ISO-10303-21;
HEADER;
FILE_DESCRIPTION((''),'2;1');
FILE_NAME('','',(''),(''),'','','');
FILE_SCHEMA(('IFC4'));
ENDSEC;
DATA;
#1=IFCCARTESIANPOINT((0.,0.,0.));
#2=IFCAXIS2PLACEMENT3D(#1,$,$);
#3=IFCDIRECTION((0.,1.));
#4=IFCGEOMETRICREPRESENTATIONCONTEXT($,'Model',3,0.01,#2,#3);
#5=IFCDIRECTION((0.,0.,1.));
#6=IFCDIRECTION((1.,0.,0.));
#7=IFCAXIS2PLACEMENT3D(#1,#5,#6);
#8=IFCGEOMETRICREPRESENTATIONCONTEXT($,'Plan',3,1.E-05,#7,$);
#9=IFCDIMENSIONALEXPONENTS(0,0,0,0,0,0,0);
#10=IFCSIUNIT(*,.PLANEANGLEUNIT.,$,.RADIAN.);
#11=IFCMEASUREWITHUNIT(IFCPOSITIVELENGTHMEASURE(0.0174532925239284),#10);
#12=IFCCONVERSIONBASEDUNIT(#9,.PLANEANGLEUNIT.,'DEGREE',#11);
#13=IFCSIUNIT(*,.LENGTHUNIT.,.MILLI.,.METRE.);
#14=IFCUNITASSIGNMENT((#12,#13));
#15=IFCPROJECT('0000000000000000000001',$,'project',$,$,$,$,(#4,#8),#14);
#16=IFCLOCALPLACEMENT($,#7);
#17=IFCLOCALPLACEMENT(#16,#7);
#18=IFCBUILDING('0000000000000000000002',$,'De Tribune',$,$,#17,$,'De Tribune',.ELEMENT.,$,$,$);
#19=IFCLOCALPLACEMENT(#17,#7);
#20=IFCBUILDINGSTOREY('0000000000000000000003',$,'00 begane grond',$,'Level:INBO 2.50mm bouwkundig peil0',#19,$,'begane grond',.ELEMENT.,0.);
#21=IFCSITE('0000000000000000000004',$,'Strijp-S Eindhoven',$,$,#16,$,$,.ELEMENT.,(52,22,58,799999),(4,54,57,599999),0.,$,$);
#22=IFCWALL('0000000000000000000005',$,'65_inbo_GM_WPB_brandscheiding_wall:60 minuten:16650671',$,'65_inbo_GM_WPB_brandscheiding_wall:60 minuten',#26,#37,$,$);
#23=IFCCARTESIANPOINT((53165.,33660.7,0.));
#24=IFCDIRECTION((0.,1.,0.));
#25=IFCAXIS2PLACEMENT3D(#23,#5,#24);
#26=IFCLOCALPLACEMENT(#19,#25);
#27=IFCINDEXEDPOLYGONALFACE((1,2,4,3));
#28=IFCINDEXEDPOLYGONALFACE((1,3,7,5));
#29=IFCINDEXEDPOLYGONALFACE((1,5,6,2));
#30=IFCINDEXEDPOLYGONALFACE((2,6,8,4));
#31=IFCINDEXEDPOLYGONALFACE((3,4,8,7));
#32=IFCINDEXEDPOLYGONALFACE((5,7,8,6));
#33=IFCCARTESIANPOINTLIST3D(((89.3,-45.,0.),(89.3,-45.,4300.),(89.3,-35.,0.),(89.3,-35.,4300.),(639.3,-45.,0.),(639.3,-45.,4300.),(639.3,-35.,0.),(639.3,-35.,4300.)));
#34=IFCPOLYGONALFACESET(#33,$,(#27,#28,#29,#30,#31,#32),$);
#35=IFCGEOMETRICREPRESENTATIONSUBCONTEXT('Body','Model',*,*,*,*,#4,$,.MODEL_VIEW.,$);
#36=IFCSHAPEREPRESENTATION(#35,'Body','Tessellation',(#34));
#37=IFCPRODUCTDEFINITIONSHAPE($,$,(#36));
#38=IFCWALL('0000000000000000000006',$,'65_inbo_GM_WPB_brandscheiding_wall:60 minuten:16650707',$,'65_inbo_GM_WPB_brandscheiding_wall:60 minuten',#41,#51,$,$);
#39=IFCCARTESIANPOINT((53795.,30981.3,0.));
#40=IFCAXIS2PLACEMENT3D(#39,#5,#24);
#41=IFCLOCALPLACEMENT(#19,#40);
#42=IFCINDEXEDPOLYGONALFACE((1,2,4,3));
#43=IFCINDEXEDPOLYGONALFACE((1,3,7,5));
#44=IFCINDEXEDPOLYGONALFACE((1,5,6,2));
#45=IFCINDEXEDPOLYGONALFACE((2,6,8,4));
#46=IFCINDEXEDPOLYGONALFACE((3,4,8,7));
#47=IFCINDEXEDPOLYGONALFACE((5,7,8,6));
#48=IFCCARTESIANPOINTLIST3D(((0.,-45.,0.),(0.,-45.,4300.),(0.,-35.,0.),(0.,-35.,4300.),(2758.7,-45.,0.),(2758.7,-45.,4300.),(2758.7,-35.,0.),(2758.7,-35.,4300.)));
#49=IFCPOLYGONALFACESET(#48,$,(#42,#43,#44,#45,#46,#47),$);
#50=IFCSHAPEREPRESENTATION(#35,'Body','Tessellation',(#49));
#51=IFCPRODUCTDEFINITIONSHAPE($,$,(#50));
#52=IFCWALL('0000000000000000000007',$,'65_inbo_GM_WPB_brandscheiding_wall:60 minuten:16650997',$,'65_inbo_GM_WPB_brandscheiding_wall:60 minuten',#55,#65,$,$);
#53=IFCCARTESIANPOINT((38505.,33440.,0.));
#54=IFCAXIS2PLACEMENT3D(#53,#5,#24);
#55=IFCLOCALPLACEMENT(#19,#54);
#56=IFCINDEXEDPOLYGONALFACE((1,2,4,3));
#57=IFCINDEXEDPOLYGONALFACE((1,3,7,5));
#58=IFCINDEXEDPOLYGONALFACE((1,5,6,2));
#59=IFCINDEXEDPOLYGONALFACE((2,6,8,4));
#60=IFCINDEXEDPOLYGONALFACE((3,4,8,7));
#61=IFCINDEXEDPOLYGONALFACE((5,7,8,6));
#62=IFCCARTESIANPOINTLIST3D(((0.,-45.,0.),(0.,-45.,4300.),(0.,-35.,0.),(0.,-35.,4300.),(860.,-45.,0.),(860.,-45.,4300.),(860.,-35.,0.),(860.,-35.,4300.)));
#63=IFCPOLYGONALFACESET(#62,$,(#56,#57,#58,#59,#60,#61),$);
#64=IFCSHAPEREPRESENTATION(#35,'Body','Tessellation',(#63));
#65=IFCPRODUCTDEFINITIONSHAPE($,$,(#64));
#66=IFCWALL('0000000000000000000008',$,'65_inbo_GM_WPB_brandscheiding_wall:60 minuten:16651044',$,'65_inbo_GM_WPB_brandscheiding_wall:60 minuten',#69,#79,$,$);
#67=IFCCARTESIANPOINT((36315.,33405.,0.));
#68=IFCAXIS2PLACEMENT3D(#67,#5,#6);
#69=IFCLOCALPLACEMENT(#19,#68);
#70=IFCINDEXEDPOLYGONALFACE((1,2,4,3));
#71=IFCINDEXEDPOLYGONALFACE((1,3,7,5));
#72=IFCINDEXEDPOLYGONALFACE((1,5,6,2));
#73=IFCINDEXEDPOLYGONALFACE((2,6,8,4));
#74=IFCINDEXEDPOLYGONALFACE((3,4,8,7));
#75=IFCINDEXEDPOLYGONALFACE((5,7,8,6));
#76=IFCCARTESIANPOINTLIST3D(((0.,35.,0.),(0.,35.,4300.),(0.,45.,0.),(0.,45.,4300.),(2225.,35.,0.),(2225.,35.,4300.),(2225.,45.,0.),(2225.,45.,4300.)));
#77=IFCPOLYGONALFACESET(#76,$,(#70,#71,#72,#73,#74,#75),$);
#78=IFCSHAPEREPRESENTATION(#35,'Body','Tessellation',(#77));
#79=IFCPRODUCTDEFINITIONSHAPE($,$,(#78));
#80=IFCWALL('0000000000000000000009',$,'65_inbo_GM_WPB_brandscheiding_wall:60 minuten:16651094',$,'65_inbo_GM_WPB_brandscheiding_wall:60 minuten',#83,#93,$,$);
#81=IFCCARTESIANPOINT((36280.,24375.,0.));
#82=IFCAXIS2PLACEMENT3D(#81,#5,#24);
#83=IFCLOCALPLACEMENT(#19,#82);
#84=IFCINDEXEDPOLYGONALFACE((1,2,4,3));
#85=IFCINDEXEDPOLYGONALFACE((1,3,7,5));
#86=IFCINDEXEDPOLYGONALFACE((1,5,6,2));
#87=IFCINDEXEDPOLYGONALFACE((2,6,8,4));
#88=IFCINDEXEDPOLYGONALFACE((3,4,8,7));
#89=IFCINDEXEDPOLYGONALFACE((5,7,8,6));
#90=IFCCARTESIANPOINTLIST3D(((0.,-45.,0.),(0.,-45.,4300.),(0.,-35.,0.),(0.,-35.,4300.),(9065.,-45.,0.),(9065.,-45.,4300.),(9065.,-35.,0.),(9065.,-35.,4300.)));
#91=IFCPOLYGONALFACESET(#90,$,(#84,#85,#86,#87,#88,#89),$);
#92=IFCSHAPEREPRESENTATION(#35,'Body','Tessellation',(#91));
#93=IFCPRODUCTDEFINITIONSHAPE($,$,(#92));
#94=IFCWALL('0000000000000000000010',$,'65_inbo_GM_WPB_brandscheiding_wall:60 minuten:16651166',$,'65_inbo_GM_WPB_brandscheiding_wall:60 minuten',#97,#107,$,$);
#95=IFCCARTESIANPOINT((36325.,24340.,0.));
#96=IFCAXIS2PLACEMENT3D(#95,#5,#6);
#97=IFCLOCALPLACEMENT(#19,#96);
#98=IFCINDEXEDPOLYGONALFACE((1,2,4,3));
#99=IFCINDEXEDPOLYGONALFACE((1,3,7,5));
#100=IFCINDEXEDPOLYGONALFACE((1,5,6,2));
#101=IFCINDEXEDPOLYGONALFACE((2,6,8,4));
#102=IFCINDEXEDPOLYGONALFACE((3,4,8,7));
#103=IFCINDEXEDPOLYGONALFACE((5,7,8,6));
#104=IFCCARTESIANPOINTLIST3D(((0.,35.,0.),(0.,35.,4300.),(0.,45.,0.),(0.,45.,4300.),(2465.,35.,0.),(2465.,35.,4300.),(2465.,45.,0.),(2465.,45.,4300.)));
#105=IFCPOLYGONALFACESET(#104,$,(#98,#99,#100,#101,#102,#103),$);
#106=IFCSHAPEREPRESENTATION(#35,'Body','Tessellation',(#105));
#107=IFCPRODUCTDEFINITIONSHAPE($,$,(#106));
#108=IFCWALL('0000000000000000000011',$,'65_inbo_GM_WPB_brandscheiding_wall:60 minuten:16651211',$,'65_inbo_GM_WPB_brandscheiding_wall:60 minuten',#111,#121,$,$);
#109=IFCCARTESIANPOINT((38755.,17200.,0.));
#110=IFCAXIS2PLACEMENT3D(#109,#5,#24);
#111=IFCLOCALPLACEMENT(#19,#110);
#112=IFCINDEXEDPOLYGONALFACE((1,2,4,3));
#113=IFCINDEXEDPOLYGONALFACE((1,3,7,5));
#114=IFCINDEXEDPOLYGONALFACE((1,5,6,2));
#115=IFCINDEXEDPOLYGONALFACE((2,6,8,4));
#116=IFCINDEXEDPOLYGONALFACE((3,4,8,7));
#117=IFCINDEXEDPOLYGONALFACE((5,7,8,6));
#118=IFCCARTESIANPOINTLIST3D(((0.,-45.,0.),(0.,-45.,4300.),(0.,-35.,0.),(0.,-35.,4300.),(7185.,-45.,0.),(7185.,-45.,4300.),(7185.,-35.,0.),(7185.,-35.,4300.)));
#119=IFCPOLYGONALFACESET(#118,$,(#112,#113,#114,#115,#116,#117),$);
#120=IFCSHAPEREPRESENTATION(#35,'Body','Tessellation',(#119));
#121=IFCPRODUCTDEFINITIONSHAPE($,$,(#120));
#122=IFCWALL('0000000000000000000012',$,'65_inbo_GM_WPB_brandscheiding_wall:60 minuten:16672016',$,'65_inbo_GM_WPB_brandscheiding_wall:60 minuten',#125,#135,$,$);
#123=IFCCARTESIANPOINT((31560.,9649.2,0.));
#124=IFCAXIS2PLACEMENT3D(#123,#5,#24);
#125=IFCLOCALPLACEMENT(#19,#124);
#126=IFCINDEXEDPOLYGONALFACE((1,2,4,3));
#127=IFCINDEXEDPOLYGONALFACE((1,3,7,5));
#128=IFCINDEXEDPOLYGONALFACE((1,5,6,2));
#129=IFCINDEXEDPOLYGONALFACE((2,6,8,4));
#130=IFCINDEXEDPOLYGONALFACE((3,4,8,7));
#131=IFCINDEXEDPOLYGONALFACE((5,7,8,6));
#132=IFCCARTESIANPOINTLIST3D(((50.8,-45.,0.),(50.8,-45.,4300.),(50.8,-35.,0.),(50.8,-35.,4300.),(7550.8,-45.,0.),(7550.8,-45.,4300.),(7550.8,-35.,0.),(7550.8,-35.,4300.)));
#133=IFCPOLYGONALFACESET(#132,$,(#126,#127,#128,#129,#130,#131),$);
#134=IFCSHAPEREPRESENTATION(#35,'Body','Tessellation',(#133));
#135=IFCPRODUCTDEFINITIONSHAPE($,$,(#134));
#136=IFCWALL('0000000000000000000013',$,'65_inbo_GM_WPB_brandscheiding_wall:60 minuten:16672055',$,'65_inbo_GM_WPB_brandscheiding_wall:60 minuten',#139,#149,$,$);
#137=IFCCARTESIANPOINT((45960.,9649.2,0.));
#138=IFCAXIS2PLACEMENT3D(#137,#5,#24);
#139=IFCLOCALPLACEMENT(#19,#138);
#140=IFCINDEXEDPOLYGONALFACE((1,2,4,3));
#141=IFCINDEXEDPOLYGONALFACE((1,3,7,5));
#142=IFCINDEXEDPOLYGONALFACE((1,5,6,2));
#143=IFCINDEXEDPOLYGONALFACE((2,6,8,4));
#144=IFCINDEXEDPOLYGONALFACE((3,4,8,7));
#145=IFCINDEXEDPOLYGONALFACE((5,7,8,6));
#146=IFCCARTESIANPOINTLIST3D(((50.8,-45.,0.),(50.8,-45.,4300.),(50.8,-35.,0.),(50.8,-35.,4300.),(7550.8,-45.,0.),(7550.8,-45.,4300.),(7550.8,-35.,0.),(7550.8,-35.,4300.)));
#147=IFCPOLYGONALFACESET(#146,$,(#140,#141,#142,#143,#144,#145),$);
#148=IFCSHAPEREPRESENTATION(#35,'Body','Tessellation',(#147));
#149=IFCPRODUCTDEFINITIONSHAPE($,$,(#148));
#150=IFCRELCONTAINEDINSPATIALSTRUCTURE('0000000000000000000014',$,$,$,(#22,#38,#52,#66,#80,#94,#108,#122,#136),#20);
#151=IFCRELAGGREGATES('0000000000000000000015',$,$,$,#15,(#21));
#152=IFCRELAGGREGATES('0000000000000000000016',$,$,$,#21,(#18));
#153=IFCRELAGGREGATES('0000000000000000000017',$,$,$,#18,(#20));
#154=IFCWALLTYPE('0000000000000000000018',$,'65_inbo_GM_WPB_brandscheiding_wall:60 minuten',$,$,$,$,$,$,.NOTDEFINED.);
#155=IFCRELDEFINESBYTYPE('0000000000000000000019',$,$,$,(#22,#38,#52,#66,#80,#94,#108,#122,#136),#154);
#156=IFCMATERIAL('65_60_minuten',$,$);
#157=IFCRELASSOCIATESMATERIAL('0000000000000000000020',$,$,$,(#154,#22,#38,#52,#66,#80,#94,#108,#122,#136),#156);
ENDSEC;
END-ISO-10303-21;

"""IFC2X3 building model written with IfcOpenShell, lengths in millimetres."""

from ifc_helpers import new_model, entity, si_unit, converted_unit, direction, frame, frame_2d, origin, origin_with_axes, place, context, subcontext, project, spatial, rectangle, extrude, material, type_object, element, save


model = new_model("IFC2X3")

# Units and contexts
model_context = context("Model", 3, precision=0.01, world=origin(), true_north=direction((0.0, 1.0)))
plan_context = context("Plan", 3, precision=1e-05, world=origin_with_axes())
body_context = subcontext(model_context, "Body", "Model", "MODEL_VIEW")
ifc_project = project(units=[converted_unit("PLANEANGLEUNIT", "DEGREE", entity("IfcPositiveLengthMeasure", 0.0174532925239284), si_unit("PLANEANGLEUNIT", "RADIAN"), dimensions=[0, 0, 0, 0, 0, 0, 0]), si_unit("LENGTHUNIT", "METRE", prefix="MILLI")], contexts=[model_context, plan_context])

# Site, building, storey
site_placement = place(None, origin_with_axes())
site = spatial("IfcSite", under=ifc_project, at=site_placement, Name="Strijp-S Eindhoven", CompositionType="ELEMENT", RefLatitude=(52, 22, 58, 799999), RefLongitude=(4, 54, 57, 599999), RefElevation=0.0)
building_placement = place(site_placement, origin_with_axes())
building = spatial("IfcBuilding", under=site, at=building_placement, Name="De Tribune", LongName="De Tribune", CompositionType="ELEMENT")
storey_placement = place(building_placement, origin_with_axes())
storey = spatial("IfcBuildingStorey", under=building, at=storey_placement, Name="00 begane grond", ObjectType="Level:INBO 2.50mm bouwkundig peil0", LongName="begane grond", CompositionType="ELEMENT", Elevation=0.0)

# Walls
ifc_material = material(Name="65_60_minuten")
wall_type = type_object("IfcWallType", Name="65_inbo_GM_WPB_brandscheiding_wall:60 minuten", PredefinedType="NOTDEFINED", material=ifc_material)
wall_1_placement = place(storey_placement, frame((53165.0, 33660.7, 0.0), z_axis=(0.0, 0.0, 1.0), x_axis=(0.0, 1.0, 0.0)))
element("IfcWall", 1, at=wall_1_placement, inside=storey, type_object=wall_type, material=ifc_material, Name="65_inbo_GM_WPB_brandscheiding_wall:60 minuten:16650671", ObjectType="65_inbo_GM_WPB_brandscheiding_wall:60 minuten", context=body_context, shape_type="SweptSolid", body=[
    extrude(rectangle(XDim=10.0, YDim=550.0, at=frame_2d((0.0, 0.0), x_axis=(1.0, 0.0))), frame((364.3, -40.0, 0.0), z_axis=(0.0, 0.0, 1.0), x_axis=(0.0, -1.0, 0.0)), (0.0, 0.0, 1.0), 4300.0),
])
wall_2_placement = place(storey_placement, frame((53795.0, 30981.3, 0.0), z_axis=(0.0, 0.0, 1.0), x_axis=(0.0, 1.0, 0.0)))
element("IfcWall", 2, at=wall_2_placement, inside=storey, type_object=wall_type, material=ifc_material, Name="65_inbo_GM_WPB_brandscheiding_wall:60 minuten:16650707", ObjectType="65_inbo_GM_WPB_brandscheiding_wall:60 minuten", context=body_context, shape_type="SweptSolid", body=[
    extrude(rectangle(XDim=10.0, YDim=2758.7, at=frame_2d((0.0, 0.0), x_axis=(1.0, 0.0))), frame((1379.3, -40.0, 0.0), z_axis=(0.0, 0.0, 1.0), x_axis=(0.0, -1.0, 0.0)), (0.0, 0.0, 1.0), 4300.0),
])
wall_3_placement = place(storey_placement, frame((38505.0, 33440.0, 0.0), z_axis=(0.0, 0.0, 1.0), x_axis=(0.0, 1.0, 0.0)))
element("IfcWall", 3, at=wall_3_placement, inside=storey, type_object=wall_type, material=ifc_material, Name="65_inbo_GM_WPB_brandscheiding_wall:60 minuten:16650997", ObjectType="65_inbo_GM_WPB_brandscheiding_wall:60 minuten", context=body_context, shape_type="SweptSolid", body=[
    extrude(rectangle(XDim=10.0, YDim=860.0, at=frame_2d((0.0, 0.0), x_axis=(1.0, 0.0))), frame((430.0, -40.0, 0.0), z_axis=(0.0, 0.0, 1.0), x_axis=(0.0, -1.0, 0.0)), (0.0, 0.0, 1.0), 4300.0),
])
wall_4_placement = place(storey_placement, frame((36315.0, 33405.0, 0.0), z_axis=(0.0, 0.0, 1.0), x_axis=(1.0, 0.0, 0.0)))
element("IfcWall", 4, at=wall_4_placement, inside=storey, type_object=wall_type, material=ifc_material, Name="65_inbo_GM_WPB_brandscheiding_wall:60 minuten:16651044", ObjectType="65_inbo_GM_WPB_brandscheiding_wall:60 minuten", context=body_context, shape_type="SweptSolid", body=[
    extrude(rectangle(XDim=2225.0, YDim=10.0, at=frame_2d((0.0, 0.0), x_axis=(1.0, 0.0))), frame((1112.5, 40.0, 0.0)), (0.0, 0.0, 1.0), 4300.0),
])
wall_5_placement = place(storey_placement, frame((36280.0, 24375.0, 0.0), z_axis=(0.0, 0.0, 1.0), x_axis=(0.0, 1.0, 0.0)))
element("IfcWall", 5, at=wall_5_placement, inside=storey, type_object=wall_type, material=ifc_material, Name="65_inbo_GM_WPB_brandscheiding_wall:60 minuten:16651094", ObjectType="65_inbo_GM_WPB_brandscheiding_wall:60 minuten", context=body_context, shape_type="SweptSolid", body=[
    extrude(rectangle(XDim=10.0, YDim=9065.0, at=frame_2d((0.0, 0.0), x_axis=(1.0, 0.0))), frame((4532.5, -40.0, 0.0), z_axis=(0.0, 0.0, 1.0), x_axis=(0.0, -1.0, 0.0)), (0.0, 0.0, 1.0), 4300.0),
])
wall_6_placement = place(storey_placement, frame((36325.0, 24340.0, 0.0), z_axis=(0.0, 0.0, 1.0), x_axis=(1.0, 0.0, 0.0)))
element("IfcWall", 6, at=wall_6_placement, inside=storey, type_object=wall_type, material=ifc_material, Name="65_inbo_GM_WPB_brandscheiding_wall:60 minuten:16651166", ObjectType="65_inbo_GM_WPB_brandscheiding_wall:60 minuten", context=body_context, shape_type="SweptSolid", body=[
    extrude(rectangle(XDim=2465.0, YDim=10.0, at=frame_2d((0.0, 0.0), x_axis=(1.0, 0.0))), frame((1232.5, 40.0, 0.0)), (0.0, 0.0, 1.0), 4300.0),
])
wall_7_placement = place(storey_placement, frame((38755.0, 17200.0, 0.0), z_axis=(0.0, 0.0, 1.0), x_axis=(0.0, 1.0, 0.0)))
element("IfcWall", 7, at=wall_7_placement, inside=storey, type_object=wall_type, material=ifc_material, Name="65_inbo_GM_WPB_brandscheiding_wall:60 minuten:16651211", ObjectType="65_inbo_GM_WPB_brandscheiding_wall:60 minuten", context=body_context, shape_type="SweptSolid", body=[
    extrude(rectangle(XDim=10.0, YDim=7185.0, at=frame_2d((0.0, 0.0), x_axis=(1.0, 0.0))), frame((3592.5, -40.0, 0.0), z_axis=(0.0, 0.0, 1.0), x_axis=(0.0, -1.0, 0.0)), (0.0, 0.0, 1.0), 4300.0),
])
wall_8_placement = place(storey_placement, frame((31560.0, 9649.2, 0.0), z_axis=(0.0, 0.0, 1.0), x_axis=(0.0, 1.0, 0.0)))
element("IfcWall", 8, at=wall_8_placement, inside=storey, type_object=wall_type, material=ifc_material, Name="65_inbo_GM_WPB_brandscheiding_wall:60 minuten:16672016", ObjectType="65_inbo_GM_WPB_brandscheiding_wall:60 minuten", context=body_context, shape_type="SweptSolid", body=[
    extrude(rectangle(XDim=7500.0, YDim=10.0, at=frame_2d((0.0, 0.0), x_axis=(1.0, 0.0))), frame((3800.8, -40.0, 0.0), z_axis=(0.0, 0.0, 1.0), x_axis=(-1.0, 0.0, 0.0)), (0.0, 0.0, 1.0), 4300.0),
])
wall_9_placement = place(storey_placement, frame((45960.0, 9649.2, 0.0), z_axis=(0.0, 0.0, 1.0), x_axis=(0.0, 1.0, 0.0)))
element("IfcWall", 9, at=wall_9_placement, inside=storey, type_object=wall_type, material=ifc_material, Name="65_inbo_GM_WPB_brandscheiding_wall:60 minuten:16672055", ObjectType="65_inbo_GM_WPB_brandscheiding_wall:60 minuten", context=body_context, shape_type="SweptSolid", body=[
    extrude(rectangle(XDim=7500.0, YDim=10.0, at=frame_2d((0.0, 0.0), x_axis=(1.0, 0.0))), frame((3800.8, -40.0, 0.0), z_axis=(0.0, 0.0, 1.0), x_axis=(-1.0, 0.0, 0.0)), (0.0, 0.0, 1.0), 4300.0),
])

save(model, "model.ifc")
